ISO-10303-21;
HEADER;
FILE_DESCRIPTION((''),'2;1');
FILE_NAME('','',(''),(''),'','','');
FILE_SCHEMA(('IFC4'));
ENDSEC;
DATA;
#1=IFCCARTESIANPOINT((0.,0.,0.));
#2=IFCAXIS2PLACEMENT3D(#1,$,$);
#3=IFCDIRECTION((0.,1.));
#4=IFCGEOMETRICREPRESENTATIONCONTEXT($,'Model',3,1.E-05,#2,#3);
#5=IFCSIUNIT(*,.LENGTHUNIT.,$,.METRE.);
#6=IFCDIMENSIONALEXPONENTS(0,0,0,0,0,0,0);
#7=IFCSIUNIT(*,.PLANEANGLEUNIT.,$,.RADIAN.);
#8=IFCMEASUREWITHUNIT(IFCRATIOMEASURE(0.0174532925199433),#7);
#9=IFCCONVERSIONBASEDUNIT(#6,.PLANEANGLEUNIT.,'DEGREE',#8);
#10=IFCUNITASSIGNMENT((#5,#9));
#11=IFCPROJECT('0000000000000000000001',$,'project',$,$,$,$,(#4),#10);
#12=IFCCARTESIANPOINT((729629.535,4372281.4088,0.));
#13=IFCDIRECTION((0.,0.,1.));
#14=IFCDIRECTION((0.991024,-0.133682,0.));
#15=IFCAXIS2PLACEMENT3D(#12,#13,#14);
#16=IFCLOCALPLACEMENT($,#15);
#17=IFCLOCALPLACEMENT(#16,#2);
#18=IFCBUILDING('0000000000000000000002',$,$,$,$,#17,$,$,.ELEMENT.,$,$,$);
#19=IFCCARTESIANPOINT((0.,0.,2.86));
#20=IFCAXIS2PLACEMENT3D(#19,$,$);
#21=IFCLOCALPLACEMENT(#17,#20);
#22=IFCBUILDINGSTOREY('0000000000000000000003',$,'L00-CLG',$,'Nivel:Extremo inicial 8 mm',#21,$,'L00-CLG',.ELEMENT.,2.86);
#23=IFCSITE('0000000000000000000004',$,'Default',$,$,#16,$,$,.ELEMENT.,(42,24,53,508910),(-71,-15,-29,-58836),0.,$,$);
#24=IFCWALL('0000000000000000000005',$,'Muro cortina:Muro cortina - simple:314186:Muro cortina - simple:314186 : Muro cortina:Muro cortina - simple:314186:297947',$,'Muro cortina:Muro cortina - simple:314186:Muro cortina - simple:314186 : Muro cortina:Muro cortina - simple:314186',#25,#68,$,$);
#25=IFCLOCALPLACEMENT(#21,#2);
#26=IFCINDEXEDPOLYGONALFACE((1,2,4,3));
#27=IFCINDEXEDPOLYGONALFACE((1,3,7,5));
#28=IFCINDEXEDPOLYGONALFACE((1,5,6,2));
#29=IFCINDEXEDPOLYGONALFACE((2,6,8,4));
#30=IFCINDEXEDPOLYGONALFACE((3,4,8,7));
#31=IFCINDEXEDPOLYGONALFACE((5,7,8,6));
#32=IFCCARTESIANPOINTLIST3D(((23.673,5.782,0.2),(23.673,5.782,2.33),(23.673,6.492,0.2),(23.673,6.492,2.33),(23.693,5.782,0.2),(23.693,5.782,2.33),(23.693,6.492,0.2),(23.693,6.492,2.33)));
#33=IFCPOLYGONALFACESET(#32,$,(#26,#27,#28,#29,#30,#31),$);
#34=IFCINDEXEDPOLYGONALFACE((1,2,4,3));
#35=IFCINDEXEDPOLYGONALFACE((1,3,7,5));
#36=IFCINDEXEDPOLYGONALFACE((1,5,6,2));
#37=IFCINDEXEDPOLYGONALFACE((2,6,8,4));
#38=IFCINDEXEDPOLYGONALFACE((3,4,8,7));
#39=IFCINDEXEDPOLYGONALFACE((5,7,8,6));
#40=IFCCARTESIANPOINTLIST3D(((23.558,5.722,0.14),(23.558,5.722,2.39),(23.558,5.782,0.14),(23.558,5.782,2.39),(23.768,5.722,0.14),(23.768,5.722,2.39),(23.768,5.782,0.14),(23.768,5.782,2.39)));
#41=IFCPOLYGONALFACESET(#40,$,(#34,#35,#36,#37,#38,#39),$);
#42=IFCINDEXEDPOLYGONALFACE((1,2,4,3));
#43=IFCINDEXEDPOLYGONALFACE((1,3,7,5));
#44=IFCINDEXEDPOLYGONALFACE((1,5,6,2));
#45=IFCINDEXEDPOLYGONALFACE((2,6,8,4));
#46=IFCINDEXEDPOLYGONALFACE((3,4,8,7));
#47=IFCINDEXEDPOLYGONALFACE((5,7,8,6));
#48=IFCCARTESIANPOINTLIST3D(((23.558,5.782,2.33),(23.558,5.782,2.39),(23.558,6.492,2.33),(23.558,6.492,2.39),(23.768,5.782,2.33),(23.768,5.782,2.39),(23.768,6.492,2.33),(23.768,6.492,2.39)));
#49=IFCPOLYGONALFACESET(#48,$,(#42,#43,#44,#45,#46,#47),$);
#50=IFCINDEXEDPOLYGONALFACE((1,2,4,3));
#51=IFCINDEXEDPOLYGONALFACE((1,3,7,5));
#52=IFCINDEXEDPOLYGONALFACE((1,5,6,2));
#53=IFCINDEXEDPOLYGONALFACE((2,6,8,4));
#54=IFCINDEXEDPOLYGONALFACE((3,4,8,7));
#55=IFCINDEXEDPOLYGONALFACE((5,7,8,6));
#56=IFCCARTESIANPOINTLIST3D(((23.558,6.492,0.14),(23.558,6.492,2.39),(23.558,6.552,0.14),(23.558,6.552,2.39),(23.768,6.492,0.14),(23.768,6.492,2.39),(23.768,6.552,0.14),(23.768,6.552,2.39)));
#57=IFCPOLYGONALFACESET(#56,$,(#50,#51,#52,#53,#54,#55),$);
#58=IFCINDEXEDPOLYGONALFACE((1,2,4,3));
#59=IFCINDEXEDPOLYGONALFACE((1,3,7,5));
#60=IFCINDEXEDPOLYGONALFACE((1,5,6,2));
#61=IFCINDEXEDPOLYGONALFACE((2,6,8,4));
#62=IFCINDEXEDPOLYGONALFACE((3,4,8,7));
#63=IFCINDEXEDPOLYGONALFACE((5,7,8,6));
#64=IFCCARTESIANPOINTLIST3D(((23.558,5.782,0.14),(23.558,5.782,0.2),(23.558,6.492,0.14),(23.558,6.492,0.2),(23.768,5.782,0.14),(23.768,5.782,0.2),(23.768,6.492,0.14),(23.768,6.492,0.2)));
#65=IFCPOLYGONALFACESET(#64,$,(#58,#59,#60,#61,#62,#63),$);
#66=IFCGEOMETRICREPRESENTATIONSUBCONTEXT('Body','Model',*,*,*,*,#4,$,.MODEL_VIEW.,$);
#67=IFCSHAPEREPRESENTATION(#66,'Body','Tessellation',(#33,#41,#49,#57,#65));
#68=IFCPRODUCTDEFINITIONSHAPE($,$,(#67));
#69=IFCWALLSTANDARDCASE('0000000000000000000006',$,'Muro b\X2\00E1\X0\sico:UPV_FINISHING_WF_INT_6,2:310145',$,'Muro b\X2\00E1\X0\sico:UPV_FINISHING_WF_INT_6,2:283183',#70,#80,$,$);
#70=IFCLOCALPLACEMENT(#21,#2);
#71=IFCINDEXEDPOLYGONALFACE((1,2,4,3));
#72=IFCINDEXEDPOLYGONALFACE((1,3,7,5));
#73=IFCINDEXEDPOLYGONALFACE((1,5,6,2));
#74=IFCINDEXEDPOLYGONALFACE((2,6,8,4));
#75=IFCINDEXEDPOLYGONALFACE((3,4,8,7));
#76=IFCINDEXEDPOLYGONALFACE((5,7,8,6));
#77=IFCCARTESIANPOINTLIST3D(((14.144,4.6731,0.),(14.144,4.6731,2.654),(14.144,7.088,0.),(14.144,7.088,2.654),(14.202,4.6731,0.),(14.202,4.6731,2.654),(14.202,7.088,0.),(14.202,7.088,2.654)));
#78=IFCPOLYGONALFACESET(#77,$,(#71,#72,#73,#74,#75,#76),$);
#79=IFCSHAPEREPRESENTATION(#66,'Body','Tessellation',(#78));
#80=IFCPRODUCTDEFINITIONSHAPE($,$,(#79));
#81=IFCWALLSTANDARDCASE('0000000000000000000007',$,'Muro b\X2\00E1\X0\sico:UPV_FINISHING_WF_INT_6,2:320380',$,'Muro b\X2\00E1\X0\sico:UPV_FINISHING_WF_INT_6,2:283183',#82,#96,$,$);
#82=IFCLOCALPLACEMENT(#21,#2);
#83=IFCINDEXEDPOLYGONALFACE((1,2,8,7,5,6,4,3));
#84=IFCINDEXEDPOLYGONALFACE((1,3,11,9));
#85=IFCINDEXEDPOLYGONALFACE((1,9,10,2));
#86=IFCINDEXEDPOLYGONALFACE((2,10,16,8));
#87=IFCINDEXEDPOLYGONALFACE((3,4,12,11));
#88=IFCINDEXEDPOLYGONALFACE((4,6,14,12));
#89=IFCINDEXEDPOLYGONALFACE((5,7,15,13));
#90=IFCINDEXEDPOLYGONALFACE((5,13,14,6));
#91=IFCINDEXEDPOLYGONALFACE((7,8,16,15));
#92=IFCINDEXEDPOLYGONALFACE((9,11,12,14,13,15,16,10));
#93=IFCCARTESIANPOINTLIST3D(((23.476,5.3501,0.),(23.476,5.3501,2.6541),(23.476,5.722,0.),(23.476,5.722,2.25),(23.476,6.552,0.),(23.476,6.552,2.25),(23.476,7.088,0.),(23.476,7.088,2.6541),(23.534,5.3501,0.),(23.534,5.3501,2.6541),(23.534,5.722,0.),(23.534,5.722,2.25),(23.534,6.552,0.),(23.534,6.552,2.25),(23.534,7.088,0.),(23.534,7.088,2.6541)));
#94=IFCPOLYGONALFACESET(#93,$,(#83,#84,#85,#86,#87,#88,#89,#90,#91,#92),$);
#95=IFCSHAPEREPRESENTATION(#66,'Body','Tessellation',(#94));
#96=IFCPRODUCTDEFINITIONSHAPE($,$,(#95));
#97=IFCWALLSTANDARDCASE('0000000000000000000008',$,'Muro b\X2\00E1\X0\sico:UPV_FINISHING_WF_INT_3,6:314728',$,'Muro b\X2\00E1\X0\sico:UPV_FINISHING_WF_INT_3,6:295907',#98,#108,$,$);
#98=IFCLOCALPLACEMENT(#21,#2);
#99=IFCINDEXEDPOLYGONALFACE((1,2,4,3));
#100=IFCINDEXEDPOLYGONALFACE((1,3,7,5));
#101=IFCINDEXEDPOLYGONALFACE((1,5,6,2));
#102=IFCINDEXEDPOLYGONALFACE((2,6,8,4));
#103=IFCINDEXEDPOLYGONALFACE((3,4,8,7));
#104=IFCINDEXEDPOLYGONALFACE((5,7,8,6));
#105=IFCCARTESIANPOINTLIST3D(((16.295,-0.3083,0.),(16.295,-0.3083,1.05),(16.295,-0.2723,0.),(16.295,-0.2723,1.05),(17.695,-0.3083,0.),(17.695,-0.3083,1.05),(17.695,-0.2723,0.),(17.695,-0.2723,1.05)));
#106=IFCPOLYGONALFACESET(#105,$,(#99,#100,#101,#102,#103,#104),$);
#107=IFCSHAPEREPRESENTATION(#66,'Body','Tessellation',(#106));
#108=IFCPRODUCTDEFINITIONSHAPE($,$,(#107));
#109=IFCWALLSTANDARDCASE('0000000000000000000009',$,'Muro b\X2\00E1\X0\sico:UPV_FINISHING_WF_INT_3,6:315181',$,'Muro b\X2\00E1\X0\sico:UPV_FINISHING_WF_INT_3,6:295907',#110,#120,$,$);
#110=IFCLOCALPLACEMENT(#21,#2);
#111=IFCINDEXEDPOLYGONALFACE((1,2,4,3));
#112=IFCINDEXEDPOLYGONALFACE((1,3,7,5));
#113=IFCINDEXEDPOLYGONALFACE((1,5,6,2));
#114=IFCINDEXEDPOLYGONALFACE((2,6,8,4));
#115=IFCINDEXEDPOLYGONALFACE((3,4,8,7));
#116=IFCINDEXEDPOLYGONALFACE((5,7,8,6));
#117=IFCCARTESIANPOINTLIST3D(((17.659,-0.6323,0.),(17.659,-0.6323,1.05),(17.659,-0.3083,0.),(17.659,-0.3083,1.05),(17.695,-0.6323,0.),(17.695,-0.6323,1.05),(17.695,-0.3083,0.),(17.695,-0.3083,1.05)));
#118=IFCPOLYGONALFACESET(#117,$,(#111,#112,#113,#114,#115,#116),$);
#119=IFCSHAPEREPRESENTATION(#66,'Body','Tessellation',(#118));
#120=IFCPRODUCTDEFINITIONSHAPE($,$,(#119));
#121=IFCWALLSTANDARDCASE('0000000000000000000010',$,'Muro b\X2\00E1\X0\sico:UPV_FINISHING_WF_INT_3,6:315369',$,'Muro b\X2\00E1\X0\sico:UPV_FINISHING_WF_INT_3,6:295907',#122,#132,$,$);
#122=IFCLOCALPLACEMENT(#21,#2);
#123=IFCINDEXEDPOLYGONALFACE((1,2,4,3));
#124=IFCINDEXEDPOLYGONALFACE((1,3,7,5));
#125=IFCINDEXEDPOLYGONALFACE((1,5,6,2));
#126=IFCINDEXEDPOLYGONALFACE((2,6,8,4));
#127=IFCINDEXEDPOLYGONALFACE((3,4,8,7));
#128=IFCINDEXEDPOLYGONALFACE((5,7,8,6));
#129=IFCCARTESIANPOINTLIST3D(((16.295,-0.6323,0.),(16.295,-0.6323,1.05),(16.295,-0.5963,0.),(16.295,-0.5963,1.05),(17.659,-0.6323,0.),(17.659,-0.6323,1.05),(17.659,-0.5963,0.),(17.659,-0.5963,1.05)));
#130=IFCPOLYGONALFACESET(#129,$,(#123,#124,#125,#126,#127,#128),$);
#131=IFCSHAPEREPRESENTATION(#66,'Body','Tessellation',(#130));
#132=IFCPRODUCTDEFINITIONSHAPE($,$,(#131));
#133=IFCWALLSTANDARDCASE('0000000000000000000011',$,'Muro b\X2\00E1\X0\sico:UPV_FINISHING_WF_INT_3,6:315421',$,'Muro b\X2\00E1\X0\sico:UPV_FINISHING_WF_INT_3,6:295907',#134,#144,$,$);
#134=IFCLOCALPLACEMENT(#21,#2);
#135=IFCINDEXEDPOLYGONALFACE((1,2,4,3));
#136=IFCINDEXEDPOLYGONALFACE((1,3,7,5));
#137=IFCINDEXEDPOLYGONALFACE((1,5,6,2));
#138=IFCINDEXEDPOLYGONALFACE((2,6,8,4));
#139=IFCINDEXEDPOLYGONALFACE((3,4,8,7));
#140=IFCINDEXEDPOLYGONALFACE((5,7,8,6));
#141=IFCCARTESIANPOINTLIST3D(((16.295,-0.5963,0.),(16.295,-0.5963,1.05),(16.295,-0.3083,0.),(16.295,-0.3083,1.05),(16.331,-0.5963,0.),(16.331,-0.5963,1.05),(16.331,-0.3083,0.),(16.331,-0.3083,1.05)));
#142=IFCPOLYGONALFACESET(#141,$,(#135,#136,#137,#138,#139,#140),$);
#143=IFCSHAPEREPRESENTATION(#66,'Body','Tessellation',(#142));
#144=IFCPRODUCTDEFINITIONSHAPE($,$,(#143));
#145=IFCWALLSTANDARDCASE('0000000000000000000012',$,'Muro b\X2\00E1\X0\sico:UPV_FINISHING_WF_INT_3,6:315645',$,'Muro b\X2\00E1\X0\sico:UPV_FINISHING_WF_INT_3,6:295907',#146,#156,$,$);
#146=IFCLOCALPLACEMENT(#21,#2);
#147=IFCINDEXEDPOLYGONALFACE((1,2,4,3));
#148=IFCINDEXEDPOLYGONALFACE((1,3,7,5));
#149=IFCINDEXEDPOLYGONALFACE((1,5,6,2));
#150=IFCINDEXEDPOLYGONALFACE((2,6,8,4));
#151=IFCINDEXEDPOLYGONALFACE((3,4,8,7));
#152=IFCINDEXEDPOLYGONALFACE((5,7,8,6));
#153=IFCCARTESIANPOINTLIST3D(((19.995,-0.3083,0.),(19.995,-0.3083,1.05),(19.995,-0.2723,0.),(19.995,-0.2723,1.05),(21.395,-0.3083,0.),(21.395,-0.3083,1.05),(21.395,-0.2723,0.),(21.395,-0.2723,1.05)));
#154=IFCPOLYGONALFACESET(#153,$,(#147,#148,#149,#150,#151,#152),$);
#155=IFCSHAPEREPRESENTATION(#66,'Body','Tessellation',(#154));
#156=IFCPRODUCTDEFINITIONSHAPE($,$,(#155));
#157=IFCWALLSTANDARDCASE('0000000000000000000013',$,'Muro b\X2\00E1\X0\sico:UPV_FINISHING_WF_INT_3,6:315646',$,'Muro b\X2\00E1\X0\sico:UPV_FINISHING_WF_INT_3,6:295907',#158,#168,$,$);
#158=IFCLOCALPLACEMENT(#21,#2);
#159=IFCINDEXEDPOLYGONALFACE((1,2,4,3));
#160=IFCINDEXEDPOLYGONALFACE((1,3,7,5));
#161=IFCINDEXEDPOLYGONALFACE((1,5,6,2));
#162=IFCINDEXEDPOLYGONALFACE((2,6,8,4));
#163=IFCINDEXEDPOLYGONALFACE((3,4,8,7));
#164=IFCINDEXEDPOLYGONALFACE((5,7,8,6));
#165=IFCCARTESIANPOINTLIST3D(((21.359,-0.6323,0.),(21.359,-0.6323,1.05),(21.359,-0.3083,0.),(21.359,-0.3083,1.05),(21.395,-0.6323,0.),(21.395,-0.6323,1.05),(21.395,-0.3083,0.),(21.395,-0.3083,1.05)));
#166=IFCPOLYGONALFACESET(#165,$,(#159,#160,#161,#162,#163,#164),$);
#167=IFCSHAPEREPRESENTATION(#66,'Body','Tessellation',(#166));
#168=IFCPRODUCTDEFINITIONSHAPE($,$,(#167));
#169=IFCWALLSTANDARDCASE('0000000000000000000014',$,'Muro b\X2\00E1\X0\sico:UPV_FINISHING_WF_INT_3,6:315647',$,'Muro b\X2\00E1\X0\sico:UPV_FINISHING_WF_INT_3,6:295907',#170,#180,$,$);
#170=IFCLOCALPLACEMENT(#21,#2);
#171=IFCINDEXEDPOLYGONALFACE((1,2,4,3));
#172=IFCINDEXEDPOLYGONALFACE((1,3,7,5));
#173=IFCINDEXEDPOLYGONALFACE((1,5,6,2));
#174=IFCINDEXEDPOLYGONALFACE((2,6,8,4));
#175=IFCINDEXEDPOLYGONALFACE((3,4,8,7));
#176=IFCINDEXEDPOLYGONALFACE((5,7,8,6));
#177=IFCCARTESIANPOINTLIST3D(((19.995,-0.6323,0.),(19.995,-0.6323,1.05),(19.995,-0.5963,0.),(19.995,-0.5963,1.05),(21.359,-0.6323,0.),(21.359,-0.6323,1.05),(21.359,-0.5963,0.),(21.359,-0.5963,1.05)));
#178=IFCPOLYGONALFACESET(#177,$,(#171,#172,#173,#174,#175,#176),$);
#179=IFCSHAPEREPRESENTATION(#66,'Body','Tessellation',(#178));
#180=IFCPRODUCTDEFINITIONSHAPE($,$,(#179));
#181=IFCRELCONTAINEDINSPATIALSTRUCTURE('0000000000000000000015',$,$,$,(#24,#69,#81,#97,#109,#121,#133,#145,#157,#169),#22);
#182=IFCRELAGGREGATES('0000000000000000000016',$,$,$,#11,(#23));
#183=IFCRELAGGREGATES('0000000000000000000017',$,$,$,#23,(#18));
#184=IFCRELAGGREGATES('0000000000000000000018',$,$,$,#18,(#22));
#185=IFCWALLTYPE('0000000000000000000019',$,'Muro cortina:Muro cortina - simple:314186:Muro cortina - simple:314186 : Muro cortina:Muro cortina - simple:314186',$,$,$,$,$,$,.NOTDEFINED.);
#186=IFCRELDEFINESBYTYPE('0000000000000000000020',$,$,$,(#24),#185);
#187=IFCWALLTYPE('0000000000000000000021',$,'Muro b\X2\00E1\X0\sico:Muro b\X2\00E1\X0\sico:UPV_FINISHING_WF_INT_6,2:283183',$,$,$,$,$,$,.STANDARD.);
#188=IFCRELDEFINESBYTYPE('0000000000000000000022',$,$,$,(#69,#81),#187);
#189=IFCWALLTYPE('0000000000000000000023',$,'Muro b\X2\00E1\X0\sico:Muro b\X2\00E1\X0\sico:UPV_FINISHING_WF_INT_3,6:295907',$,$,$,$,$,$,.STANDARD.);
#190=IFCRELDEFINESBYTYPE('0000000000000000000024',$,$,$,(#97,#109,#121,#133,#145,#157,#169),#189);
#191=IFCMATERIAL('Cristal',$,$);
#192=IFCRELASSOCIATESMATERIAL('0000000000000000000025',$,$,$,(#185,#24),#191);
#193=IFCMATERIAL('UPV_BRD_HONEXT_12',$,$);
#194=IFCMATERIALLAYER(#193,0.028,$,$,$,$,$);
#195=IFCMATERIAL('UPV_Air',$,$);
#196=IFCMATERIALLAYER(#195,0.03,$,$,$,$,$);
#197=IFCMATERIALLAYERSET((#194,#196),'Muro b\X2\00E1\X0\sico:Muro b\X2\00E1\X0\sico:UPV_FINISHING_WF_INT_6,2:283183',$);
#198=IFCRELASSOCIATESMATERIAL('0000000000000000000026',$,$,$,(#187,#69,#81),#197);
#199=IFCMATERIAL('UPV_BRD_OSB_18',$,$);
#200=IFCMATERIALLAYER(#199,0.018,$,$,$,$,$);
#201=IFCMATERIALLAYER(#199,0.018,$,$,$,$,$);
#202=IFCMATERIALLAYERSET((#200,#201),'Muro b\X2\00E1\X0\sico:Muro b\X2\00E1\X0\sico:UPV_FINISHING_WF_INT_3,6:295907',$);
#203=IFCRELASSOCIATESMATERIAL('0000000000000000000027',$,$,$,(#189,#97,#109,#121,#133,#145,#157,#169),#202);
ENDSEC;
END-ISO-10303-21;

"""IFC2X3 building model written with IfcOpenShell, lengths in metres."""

from ifc_helpers import new_model, entity, si_unit, converted_unit, direction, frame, frame_2d, origin, place, context, subcontext, project, spatial, rectangle, extrude, material, layer, layer_set, layer_usage, type_object, element, save


model = new_model("IFC2X3")

# Units and contexts
model_context = context("Model", 3, precision=1e-05, world=origin(), true_north=direction((0.0, 1.0)))
body_context = subcontext(model_context, "Body", "Model", "MODEL_VIEW")
ifc_project = project(units=[si_unit("LENGTHUNIT", "METRE"), converted_unit("PLANEANGLEUNIT", "DEGREE", entity("IfcRatioMeasure", 0.0174532925199433), si_unit("PLANEANGLEUNIT", "RADIAN"), dimensions=[0, 0, 0, 0, 0, 0, 0])], contexts=[model_context])

# Site, building, storey
site_placement = place(None, frame((729629.535, 4372281.4088, 0.0), z_axis=(0.0, 0.0, 1.0), x_axis=(0.991024, -0.133682, 0.0)))
site = spatial("IfcSite", under=ifc_project, at=site_placement, Name="Default", CompositionType="ELEMENT", RefLatitude=(42, 24, 53, 508910), RefLongitude=(-71, -15, -29, -58836), RefElevation=0.0)
building_placement = place(site_placement, origin())
building = spatial("IfcBuilding", under=site, at=building_placement, CompositionType="ELEMENT")
storey_placement = place(building_placement, frame((0.0, 0.0, 2.86)))
storey = spatial("IfcBuildingStorey", under=building, at=storey_placement, Name="L00-CLG", ObjectType="Nivel:Extremo inicial 8 mm", LongName="L00-CLG", CompositionType="ELEMENT", Elevation=2.86)

# Walls
ifc_material_1 = material(Name="Cristal")
wall_type_1 = type_object("IfcWallType", Name="Muro cortina:Muro cortina - simple:314186:Muro cortina - simple:314186 : Muro cortina:Muro cortina - simple:314186", PredefinedType="NOTDEFINED", material=ifc_material_1)
wall_1_placement = place(storey_placement, frame((23.558, 5.722, 0.14), z_axis=(0.0, 0.0, 1.0), x_axis=(0.0, 1.0, 0.0)))
element("IfcWall", 1, at=wall_1_placement, inside=storey, type_object=wall_type_1, material=ifc_material_1, Name="Muro cortina:Muro cortina - simple:314186:Muro cortina - simple:314186 : Muro cortina:Muro cortina - simple:314186:297947", ObjectType="Muro cortina:Muro cortina - simple:314186:Muro cortina - simple:314186 : Muro cortina:Muro cortina - simple:314186", context=body_context, shape_type="SweptSolid", body=[
    extrude(rectangle(XDim=0.71, YDim=0.02, at=frame_2d((0.0, 0.0), x_axis=(1.0, 0.0))), frame((0.415, -0.125, 0.06)), (0.0, 0.0, 1.0), 2.13),
    extrude(rectangle(XDim=0.21, YDim=0.06, at=frame_2d((0.0, 0.0), x_axis=(1.0, 0.0))), frame((0.03, -0.105, 0.0), z_axis=(0.0, 0.0, 1.0), x_axis=(0.0, 1.0, 0.0)), (0.0, 0.0, 1.0), 2.25),
    extrude(rectangle(XDim=0.71, YDim=0.21, at=frame_2d((0.0, 0.0), x_axis=(1.0, 0.0))), frame((0.415, -0.105, 2.19)), (0.0, 0.0, 1.0), 0.06),
    extrude(rectangle(XDim=0.06, YDim=0.21, at=frame_2d((0.0, 0.0), x_axis=(1.0, 0.0))), frame((0.8, -0.105, 0.0)), (0.0, 0.0, 1.0), 2.25),
    extrude(rectangle(XDim=0.71, YDim=0.21, at=frame_2d((0.0, 0.0), x_axis=(1.0, 0.0))), frame((0.415, -0.105, 0.0), z_axis=(0.0, 0.0, 1.0), x_axis=(-1.0, 0.0, 0.0)), (0.0, 0.0, 1.0), 0.06),
])
ifc_material_2 = material(Name="UPV_BRD_HONEXT_12")
ifc_layer_1 = layer(ifc_material_2, 0.028)
ifc_material_3 = material(Name="UPV_Air")
ifc_layer_2 = layer(ifc_material_3, 0.03)
ifc_layer_set_1 = layer_set([ifc_layer_1, ifc_layer_2], Name="Muro básico:Muro básico:UPV_FINISHING_WF_INT_6,2:283183")
ifc_layer_usage_1 = layer_usage(ifc_layer_set_1, "AXIS2", "NEGATIVE", 0.029)
wall_type_2 = type_object("IfcWallType", Name="Muro básico:Muro básico:UPV_FINISHING_WF_INT_6,2:283183", PredefinedType="STANDARD", material=ifc_layer_set_1)
wall_2_placement = place(storey_placement, frame((14.173, 7.088, 0.0), z_axis=(0.0, 0.0, 1.0), x_axis=(0.0, -1.0, 0.0)))
element("IfcWallStandardCase", 2, at=wall_2_placement, inside=storey, type_object=wall_type_2, material=ifc_layer_usage_1, Name="Muro básico:UPV_FINISHING_WF_INT_6,2:310145", ObjectType="Muro básico:UPV_FINISHING_WF_INT_6,2:283183", context=body_context, shape_type="SweptSolid", body=[
    extrude(rectangle(XDim=2.4149, YDim=0.058, at=frame_2d((1.2075, 0.0), x_axis=(-1.0, 0.0))), origin(), (0.0, 0.0, 1.0), 2.654),
])

# Wall, opening
ifc_layer_usage_2 = layer_usage(ifc_layer_set_1, "AXIS2", "NEGATIVE", 0.029)
wall_3_placement = place(storey_placement, frame((23.505, 5.3501, 0.0), z_axis=(0.0, 0.0, 1.0), x_axis=(0.0, 1.0, 0.0)))
wall_3 = element("IfcWallStandardCase", 3, at=wall_3_placement, inside=storey, type_object=wall_type_2, material=ifc_layer_usage_2, Name="Muro básico:UPV_FINISHING_WF_INT_6,2:320380", ObjectType="Muro básico:UPV_FINISHING_WF_INT_6,2:283183", context=body_context, shape_type="SweptSolid", body=[
    extrude(rectangle(XDim=1.7379, YDim=0.058, at=frame_2d((0.869, 0.0), x_axis=(-1.0, 0.0))), origin(), (0.0, 0.0, 1.0), 2.6541),
])
opening_placement = place(wall_3_placement, origin())
element("IfcOpeningElement", 4, at=opening_placement, cuts=wall_3, ObjectType="Opening", context=body_context, shape_type="SweptSolid", body=[
    extrude(rectangle(XDim=2.25, YDim=0.83, at=frame_2d((0.0, 0.0), x_axis=(1.0, 0.0))), frame((0.7869, -0.029, 1.125), z_axis=(0.0, 1.0, 0.0), x_axis=(0.0, 0.0, -1.0)), (0.0, 0.0, 1.0), 0.058),
])

# Walls
ifc_material_4 = material(Name="UPV_BRD_OSB_18")
ifc_layer_3 = layer(ifc_material_4, 0.018)
ifc_layer_4 = layer(ifc_material_4, 0.018)
ifc_layer_set_2 = layer_set([ifc_layer_3, ifc_layer_4], Name="Muro básico:Muro básico:UPV_FINISHING_WF_INT_3,6:295907")
ifc_layer_usage_3 = layer_usage(ifc_layer_set_2, "AXIS2", "NEGATIVE", 0.018)
wall_type_3 = type_object("IfcWallType", Name="Muro básico:Muro básico:UPV_FINISHING_WF_INT_3,6:295907", PredefinedType="STANDARD", material=ifc_layer_set_2)
wall_4_placement = place(storey_placement, frame((16.295, -0.2903, 0.0)))
element("IfcWallStandardCase", 5, at=wall_4_placement, inside=storey, type_object=wall_type_3, material=ifc_layer_usage_3, Name="Muro básico:UPV_FINISHING_WF_INT_3,6:314728", ObjectType="Muro básico:UPV_FINISHING_WF_INT_3,6:295907", context=body_context, shape_type="SweptSolid", body=[
    extrude(rectangle(XDim=1.4, YDim=0.036, at=frame_2d((0.7, 0.0), x_axis=(-1.0, 0.0))), origin(), (0.0, 0.0, 1.0), 1.05),
])
ifc_layer_usage_4 = layer_usage(ifc_layer_set_2, "AXIS2", "NEGATIVE", 0.018)
wall_5_placement = place(storey_placement, frame((17.677, -0.3083, 0.0), z_axis=(0.0, 0.0, 1.0), x_axis=(0.0, -1.0, 0.0)))
element("IfcWallStandardCase", 6, at=wall_5_placement, inside=storey, type_object=wall_type_3, material=ifc_layer_usage_4, Name="Muro básico:UPV_FINISHING_WF_INT_3,6:315181", ObjectType="Muro básico:UPV_FINISHING_WF_INT_3,6:295907", context=body_context, shape_type="SweptSolid", body=[
    extrude(rectangle(XDim=0.324, YDim=0.036, at=frame_2d((0.162, 0.0), x_axis=(-1.0, 0.0))), origin(), (0.0, 0.0, 1.0), 1.05),
])
ifc_layer_usage_5 = layer_usage(ifc_layer_set_2, "AXIS2", "NEGATIVE", 0.018)
wall_6_placement = place(storey_placement, frame((17.659, -0.6143, 0.0), z_axis=(0.0, 0.0, 1.0), x_axis=(-1.0, 0.0, 0.0)))
element("IfcWallStandardCase", 7, at=wall_6_placement, inside=storey, type_object=wall_type_3, material=ifc_layer_usage_5, Name="Muro básico:UPV_FINISHING_WF_INT_3,6:315369", ObjectType="Muro básico:UPV_FINISHING_WF_INT_3,6:295907", context=body_context, shape_type="SweptSolid", body=[
    extrude(rectangle(XDim=1.364, YDim=0.036, at=frame_2d((0.682, 0.0), x_axis=(-1.0, 0.0))), origin(), (0.0, 0.0, 1.0), 1.05),
])
ifc_layer_usage_6 = layer_usage(ifc_layer_set_2, "AXIS2", "NEGATIVE", 0.018)
wall_7_placement = place(storey_placement, frame((16.313, -0.5963, 0.0), z_axis=(0.0, 0.0, 1.0), x_axis=(0.0, 1.0, 0.0)))
element("IfcWallStandardCase", 8, at=wall_7_placement, inside=storey, type_object=wall_type_3, material=ifc_layer_usage_6, Name="Muro básico:UPV_FINISHING_WF_INT_3,6:315421", ObjectType="Muro básico:UPV_FINISHING_WF_INT_3,6:295907", context=body_context, shape_type="SweptSolid", body=[
    extrude(rectangle(XDim=0.288, YDim=0.036, at=frame_2d((0.144, 0.0), x_axis=(-1.0, 0.0))), origin(), (0.0, 0.0, 1.0), 1.05),
])
ifc_layer_usage_7 = layer_usage(ifc_layer_set_2, "AXIS2", "NEGATIVE", 0.018)
wall_8_placement = place(storey_placement, frame((19.995, -0.2903, 0.0)))
element("IfcWallStandardCase", 9, at=wall_8_placement, inside=storey, type_object=wall_type_3, material=ifc_layer_usage_7, Name="Muro básico:UPV_FINISHING_WF_INT_3,6:315645", ObjectType="Muro básico:UPV_FINISHING_WF_INT_3,6:295907", context=body_context, shape_type="SweptSolid", body=[
    extrude(rectangle(XDim=1.4, YDim=0.036, at=frame_2d((0.7, 0.0), x_axis=(-1.0, 0.0))), origin(), (0.0, 0.0, 1.0), 1.05),
])
ifc_layer_usage_8 = layer_usage(ifc_layer_set_2, "AXIS2", "NEGATIVE", 0.018)
wall_9_placement = place(storey_placement, frame((21.377, -0.3083, 0.0), z_axis=(0.0, 0.0, 1.0), x_axis=(0.0, -1.0, 0.0)))
element("IfcWallStandardCase", 10, at=wall_9_placement, inside=storey, type_object=wall_type_3, material=ifc_layer_usage_8, Name="Muro básico:UPV_FINISHING_WF_INT_3,6:315646", ObjectType="Muro básico:UPV_FINISHING_WF_INT_3,6:295907", context=body_context, shape_type="SweptSolid", body=[
    extrude(rectangle(XDim=0.324, YDim=0.036, at=frame_2d((0.162, 0.0), x_axis=(-1.0, 0.0))), origin(), (0.0, 0.0, 1.0), 1.05),
])
ifc_layer_usage_9 = layer_usage(ifc_layer_set_2, "AXIS2", "NEGATIVE", 0.018)
wall_10_placement = place(storey_placement, frame((21.359, -0.6143, 0.0), z_axis=(0.0, 0.0, 1.0), x_axis=(-1.0, 0.0, 0.0)))
element("IfcWallStandardCase", 11, at=wall_10_placement, inside=storey, type_object=wall_type_3, material=ifc_layer_usage_9, Name="Muro básico:UPV_FINISHING_WF_INT_3,6:315647", ObjectType="Muro básico:UPV_FINISHING_WF_INT_3,6:295907", context=body_context, shape_type="SweptSolid", body=[
    extrude(rectangle(XDim=1.364, YDim=0.036, at=frame_2d((0.682, 0.0), x_axis=(-1.0, 0.0))), origin(), (0.0, 0.0, 1.0), 1.05),
])

save(model, "model.ifc")
